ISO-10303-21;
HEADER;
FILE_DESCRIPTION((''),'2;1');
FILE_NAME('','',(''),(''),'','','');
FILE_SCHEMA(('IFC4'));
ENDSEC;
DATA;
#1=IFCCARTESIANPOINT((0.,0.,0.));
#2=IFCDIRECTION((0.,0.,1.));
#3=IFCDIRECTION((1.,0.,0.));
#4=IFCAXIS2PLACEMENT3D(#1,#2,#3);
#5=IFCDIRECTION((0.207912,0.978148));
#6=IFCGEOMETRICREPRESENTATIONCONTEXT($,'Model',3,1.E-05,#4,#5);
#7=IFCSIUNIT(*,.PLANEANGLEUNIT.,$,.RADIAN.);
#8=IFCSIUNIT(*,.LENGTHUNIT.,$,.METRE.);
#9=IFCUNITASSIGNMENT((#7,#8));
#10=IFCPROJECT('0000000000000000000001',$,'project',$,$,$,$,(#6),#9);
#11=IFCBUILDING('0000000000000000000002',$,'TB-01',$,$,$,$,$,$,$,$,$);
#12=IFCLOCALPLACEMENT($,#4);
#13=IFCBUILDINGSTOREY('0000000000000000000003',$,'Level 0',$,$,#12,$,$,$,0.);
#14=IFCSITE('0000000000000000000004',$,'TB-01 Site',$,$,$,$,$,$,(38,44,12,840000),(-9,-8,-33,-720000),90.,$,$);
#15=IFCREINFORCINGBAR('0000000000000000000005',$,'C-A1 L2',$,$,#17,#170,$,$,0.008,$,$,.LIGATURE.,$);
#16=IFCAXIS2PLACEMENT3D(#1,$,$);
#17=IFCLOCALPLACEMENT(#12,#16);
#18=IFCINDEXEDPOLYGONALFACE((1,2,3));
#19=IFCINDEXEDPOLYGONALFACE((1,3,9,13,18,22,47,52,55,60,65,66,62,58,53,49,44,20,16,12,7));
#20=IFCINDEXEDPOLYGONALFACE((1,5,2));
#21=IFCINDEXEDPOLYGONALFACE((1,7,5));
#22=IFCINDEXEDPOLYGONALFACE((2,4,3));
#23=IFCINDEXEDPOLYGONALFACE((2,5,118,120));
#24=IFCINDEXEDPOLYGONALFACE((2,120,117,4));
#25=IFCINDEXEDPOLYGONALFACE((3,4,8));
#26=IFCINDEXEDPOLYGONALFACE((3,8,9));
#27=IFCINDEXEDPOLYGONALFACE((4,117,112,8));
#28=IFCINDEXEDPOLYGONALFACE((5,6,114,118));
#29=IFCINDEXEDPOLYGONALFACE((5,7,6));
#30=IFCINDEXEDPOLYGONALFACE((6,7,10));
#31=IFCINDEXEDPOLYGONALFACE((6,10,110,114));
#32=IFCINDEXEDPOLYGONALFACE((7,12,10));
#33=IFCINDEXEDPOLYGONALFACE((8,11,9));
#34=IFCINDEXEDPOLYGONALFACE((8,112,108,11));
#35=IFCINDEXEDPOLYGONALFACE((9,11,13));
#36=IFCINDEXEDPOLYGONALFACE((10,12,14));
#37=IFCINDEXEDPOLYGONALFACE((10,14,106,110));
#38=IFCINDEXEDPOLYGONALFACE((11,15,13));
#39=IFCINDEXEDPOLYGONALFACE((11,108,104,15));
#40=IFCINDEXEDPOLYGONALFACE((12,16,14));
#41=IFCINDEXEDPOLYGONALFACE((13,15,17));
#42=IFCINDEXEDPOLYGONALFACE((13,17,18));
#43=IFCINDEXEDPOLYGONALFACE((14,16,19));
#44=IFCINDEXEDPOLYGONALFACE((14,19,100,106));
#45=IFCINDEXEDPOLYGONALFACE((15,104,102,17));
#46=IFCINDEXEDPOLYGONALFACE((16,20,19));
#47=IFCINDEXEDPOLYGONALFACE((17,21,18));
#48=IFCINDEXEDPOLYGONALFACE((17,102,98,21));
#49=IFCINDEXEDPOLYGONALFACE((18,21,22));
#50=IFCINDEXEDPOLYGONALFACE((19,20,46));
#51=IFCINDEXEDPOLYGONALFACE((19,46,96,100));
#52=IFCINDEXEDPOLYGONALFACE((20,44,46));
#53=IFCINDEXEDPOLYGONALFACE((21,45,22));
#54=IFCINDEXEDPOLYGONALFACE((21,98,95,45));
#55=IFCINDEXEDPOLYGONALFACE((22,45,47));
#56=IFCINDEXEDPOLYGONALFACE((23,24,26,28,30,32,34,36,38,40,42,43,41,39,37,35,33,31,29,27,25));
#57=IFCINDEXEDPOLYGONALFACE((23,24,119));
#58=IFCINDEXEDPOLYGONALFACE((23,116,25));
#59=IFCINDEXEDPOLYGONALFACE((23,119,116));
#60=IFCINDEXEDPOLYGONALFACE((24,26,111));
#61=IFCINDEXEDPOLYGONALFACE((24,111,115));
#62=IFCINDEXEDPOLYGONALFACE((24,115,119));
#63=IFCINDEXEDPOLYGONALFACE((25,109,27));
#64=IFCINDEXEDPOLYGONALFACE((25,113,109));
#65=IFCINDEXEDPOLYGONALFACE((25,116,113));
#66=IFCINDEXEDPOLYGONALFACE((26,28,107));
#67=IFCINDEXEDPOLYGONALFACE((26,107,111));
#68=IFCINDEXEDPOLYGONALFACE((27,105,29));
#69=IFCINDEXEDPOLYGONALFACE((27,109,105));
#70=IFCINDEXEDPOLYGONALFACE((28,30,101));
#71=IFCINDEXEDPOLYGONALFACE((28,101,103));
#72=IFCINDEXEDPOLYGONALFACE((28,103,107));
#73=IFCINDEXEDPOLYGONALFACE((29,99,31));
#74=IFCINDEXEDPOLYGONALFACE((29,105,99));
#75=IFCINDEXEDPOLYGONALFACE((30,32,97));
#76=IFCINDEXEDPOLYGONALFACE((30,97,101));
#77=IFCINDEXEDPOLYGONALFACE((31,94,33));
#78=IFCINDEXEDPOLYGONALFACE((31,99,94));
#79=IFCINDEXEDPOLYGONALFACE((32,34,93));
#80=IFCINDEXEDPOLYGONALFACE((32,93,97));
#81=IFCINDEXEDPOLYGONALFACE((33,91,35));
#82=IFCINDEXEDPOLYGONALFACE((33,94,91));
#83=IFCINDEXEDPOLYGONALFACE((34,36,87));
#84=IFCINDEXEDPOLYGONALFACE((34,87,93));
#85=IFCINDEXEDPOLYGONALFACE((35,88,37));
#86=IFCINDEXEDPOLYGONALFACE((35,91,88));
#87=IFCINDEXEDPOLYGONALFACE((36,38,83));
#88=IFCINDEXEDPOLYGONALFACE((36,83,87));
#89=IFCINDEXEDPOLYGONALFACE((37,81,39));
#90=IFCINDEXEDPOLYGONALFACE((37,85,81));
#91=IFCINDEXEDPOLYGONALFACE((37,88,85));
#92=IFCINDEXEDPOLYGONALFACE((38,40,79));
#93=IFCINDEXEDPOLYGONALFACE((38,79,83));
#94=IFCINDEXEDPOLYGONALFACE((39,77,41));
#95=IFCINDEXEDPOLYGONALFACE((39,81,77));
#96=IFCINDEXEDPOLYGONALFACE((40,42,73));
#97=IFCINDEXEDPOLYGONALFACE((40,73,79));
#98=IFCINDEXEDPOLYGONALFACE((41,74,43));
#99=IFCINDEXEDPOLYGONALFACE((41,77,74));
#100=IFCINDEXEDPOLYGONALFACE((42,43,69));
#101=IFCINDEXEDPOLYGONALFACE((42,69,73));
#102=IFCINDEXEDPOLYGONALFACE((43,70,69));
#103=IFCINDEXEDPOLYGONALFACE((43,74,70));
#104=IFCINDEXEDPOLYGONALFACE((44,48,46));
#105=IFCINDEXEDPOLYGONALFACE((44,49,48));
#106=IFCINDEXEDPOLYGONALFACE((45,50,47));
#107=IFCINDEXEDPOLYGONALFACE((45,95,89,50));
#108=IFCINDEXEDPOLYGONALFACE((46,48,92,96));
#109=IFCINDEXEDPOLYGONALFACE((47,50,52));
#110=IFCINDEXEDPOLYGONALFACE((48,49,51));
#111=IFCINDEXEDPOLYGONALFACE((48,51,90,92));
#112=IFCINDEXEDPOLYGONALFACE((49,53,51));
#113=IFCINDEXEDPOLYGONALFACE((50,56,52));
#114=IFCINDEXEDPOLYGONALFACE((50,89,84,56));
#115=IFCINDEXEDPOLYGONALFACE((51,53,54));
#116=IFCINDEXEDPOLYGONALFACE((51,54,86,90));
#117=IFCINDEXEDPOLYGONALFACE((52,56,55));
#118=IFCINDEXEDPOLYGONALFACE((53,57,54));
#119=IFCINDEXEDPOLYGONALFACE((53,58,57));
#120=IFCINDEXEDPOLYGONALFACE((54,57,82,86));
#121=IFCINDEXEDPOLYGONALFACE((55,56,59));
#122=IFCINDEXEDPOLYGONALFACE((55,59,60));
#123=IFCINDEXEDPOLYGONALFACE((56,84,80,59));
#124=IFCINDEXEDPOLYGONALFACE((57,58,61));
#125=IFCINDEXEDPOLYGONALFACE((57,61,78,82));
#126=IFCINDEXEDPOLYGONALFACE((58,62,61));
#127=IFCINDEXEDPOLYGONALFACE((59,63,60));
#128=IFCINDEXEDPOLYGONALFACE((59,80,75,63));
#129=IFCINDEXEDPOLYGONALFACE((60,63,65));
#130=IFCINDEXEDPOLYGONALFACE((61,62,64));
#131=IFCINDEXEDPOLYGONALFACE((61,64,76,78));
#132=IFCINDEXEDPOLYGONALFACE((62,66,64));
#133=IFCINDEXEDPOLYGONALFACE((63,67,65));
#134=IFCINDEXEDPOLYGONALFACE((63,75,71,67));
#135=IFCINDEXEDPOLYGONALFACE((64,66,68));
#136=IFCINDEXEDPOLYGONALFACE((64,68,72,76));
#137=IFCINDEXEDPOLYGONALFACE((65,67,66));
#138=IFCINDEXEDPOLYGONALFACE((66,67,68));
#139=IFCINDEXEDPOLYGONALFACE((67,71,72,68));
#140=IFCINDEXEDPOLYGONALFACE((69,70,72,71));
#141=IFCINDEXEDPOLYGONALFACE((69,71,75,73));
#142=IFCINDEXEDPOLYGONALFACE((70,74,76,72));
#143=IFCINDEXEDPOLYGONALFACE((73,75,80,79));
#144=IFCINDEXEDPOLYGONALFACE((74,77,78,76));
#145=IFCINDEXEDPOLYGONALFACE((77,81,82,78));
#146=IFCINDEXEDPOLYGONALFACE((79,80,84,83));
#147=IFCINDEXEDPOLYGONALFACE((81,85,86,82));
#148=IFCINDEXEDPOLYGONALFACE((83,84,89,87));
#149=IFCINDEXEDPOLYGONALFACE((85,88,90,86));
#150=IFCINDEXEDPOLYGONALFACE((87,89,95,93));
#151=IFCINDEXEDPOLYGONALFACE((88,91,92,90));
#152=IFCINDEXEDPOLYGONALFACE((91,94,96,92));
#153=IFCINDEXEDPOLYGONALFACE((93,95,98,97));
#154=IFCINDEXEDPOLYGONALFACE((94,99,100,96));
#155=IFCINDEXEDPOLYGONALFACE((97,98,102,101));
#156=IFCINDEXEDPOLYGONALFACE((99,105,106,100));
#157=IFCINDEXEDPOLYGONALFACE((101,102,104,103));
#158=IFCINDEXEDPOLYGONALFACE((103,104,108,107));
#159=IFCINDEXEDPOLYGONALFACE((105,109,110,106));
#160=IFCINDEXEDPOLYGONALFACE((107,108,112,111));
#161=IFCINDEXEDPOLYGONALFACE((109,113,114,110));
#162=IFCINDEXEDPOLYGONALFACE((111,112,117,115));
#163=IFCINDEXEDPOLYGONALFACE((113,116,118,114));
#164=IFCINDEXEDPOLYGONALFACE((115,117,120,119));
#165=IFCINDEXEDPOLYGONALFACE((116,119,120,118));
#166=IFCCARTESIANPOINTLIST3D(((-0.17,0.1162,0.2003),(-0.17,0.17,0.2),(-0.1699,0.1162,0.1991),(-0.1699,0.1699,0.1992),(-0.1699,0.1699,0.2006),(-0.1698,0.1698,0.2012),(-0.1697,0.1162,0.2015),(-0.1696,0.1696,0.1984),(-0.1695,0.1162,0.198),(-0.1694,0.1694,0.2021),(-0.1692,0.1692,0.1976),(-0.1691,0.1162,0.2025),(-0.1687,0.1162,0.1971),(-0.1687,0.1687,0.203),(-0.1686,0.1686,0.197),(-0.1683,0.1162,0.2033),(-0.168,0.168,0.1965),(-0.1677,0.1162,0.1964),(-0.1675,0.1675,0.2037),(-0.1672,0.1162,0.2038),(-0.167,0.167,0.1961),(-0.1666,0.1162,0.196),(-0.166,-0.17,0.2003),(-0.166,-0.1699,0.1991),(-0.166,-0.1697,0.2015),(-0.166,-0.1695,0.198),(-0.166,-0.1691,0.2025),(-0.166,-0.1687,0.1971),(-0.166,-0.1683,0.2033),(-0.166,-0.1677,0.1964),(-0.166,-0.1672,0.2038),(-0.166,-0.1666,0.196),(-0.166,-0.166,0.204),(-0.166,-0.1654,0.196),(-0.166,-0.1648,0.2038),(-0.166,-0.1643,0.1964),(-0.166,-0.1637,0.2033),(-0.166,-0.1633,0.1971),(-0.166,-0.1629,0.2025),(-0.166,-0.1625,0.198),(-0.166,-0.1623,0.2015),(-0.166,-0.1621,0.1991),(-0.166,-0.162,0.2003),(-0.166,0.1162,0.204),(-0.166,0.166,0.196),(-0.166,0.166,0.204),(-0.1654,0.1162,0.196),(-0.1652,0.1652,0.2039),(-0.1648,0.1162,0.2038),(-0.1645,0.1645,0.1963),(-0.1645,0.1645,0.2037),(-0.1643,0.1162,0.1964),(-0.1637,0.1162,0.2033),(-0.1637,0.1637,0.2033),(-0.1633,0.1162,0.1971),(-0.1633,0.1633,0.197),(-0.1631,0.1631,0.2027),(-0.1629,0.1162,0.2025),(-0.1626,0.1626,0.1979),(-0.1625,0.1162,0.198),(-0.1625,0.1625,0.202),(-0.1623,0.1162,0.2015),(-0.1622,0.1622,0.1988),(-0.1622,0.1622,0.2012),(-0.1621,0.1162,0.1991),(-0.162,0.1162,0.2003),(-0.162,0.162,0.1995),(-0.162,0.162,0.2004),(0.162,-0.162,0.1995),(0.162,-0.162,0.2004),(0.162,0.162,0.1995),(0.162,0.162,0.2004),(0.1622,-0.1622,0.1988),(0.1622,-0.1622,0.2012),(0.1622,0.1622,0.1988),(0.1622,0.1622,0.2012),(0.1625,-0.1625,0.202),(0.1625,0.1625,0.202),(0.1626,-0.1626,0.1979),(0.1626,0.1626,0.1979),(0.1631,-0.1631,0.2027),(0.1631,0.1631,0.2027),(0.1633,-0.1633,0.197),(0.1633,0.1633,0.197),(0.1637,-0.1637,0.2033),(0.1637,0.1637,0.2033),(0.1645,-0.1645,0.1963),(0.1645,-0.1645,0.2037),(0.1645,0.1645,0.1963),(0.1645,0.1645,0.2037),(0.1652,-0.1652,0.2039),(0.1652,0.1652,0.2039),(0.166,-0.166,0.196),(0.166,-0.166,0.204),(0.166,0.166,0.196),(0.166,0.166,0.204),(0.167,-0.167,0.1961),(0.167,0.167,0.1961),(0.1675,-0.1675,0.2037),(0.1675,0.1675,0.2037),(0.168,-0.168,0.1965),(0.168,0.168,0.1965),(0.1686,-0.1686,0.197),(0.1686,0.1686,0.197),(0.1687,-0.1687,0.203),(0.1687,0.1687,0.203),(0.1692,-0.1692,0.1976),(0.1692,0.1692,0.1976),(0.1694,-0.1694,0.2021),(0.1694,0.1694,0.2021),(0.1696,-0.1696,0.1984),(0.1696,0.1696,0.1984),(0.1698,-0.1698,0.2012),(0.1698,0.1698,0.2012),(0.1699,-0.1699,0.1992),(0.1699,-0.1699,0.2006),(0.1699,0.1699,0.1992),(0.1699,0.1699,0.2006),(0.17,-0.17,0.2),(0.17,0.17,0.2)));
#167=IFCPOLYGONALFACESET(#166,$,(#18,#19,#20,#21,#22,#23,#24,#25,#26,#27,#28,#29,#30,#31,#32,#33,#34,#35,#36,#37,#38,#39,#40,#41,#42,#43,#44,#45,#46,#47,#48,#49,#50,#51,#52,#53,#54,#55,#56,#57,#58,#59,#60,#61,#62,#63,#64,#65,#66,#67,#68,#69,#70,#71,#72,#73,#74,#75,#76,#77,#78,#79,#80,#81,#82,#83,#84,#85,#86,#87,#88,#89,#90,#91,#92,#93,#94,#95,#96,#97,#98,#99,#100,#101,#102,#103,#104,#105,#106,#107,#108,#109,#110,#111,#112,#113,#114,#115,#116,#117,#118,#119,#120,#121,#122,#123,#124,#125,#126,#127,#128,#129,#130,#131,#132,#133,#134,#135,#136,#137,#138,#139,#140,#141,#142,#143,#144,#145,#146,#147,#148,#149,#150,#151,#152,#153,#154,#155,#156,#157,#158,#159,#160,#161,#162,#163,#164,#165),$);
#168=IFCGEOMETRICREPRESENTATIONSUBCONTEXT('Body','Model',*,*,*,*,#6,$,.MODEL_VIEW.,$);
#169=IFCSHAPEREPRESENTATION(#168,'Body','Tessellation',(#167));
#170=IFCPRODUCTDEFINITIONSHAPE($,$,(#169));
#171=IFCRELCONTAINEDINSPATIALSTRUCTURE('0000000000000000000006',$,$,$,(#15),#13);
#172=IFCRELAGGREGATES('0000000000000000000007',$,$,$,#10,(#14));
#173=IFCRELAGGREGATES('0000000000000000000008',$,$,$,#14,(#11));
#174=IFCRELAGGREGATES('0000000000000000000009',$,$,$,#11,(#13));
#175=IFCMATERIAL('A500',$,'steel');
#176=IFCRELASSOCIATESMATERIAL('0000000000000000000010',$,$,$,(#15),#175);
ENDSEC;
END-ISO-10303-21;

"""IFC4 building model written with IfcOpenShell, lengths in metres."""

from ifc_helpers import new_model, entity, si_unit, direction, origin_with_axes, place, context, subcontext, project, spatial, material, element, save


model = new_model("IFC4")

# Units and contexts
model_context = context("Model", 3, precision=1e-05, world=origin_with_axes(), true_north=direction((0.207912, 0.978148)))
body_context = subcontext(model_context, "Body", "Model", "MODEL_VIEW")
ifc_project = project(units=[si_unit("PLANEANGLEUNIT", "RADIAN"), si_unit("LENGTHUNIT", "METRE")], contexts=[model_context])

# Site, building, storey
site = spatial("IfcSite", under=ifc_project, Name="TB-01 Site", RefLatitude=(38, 44, 12, 840000), RefLongitude=(-9, -8, -33, -720000), RefElevation=90.0)
building = spatial("IfcBuilding", under=site, Name="TB-01")
storey_placement = place(None, origin_with_axes())
storey = spatial("IfcBuildingStorey", under=building, at=storey_placement, Name="Level 0", Elevation=0.0)

# Reinforcing bar
ifc_material_1 = material(Name="A500", Category="steel")
reinforcing_bar_1_placement = place(storey_placement, origin_with_axes())
element("IfcReinforcingBar", 1, at=reinforcing_bar_1_placement, inside=storey, material=ifc_material_1, Name="C-A1 L2", NominalDiameter=0.008, PredefinedType="LIGATURE", context=body_context, shape_type="AdvancedSweptSolid", body=[
    entity("IfcSweptDiskSolid", entity("IfcPolyline", [entity("IfcCartesianPoint", [-0.166, -0.166, 0.2]), entity("IfcCartesianPoint", [0.166, -0.166, 0.2]), entity("IfcCartesianPoint", [0.166, 0.166, 0.2]), entity("IfcCartesianPoint", [-0.166, 0.166, 0.2]), entity("IfcCartesianPoint", [-0.166, 0.1162, 0.2])]), 0.004),
])

save(model, "model.ifc")
